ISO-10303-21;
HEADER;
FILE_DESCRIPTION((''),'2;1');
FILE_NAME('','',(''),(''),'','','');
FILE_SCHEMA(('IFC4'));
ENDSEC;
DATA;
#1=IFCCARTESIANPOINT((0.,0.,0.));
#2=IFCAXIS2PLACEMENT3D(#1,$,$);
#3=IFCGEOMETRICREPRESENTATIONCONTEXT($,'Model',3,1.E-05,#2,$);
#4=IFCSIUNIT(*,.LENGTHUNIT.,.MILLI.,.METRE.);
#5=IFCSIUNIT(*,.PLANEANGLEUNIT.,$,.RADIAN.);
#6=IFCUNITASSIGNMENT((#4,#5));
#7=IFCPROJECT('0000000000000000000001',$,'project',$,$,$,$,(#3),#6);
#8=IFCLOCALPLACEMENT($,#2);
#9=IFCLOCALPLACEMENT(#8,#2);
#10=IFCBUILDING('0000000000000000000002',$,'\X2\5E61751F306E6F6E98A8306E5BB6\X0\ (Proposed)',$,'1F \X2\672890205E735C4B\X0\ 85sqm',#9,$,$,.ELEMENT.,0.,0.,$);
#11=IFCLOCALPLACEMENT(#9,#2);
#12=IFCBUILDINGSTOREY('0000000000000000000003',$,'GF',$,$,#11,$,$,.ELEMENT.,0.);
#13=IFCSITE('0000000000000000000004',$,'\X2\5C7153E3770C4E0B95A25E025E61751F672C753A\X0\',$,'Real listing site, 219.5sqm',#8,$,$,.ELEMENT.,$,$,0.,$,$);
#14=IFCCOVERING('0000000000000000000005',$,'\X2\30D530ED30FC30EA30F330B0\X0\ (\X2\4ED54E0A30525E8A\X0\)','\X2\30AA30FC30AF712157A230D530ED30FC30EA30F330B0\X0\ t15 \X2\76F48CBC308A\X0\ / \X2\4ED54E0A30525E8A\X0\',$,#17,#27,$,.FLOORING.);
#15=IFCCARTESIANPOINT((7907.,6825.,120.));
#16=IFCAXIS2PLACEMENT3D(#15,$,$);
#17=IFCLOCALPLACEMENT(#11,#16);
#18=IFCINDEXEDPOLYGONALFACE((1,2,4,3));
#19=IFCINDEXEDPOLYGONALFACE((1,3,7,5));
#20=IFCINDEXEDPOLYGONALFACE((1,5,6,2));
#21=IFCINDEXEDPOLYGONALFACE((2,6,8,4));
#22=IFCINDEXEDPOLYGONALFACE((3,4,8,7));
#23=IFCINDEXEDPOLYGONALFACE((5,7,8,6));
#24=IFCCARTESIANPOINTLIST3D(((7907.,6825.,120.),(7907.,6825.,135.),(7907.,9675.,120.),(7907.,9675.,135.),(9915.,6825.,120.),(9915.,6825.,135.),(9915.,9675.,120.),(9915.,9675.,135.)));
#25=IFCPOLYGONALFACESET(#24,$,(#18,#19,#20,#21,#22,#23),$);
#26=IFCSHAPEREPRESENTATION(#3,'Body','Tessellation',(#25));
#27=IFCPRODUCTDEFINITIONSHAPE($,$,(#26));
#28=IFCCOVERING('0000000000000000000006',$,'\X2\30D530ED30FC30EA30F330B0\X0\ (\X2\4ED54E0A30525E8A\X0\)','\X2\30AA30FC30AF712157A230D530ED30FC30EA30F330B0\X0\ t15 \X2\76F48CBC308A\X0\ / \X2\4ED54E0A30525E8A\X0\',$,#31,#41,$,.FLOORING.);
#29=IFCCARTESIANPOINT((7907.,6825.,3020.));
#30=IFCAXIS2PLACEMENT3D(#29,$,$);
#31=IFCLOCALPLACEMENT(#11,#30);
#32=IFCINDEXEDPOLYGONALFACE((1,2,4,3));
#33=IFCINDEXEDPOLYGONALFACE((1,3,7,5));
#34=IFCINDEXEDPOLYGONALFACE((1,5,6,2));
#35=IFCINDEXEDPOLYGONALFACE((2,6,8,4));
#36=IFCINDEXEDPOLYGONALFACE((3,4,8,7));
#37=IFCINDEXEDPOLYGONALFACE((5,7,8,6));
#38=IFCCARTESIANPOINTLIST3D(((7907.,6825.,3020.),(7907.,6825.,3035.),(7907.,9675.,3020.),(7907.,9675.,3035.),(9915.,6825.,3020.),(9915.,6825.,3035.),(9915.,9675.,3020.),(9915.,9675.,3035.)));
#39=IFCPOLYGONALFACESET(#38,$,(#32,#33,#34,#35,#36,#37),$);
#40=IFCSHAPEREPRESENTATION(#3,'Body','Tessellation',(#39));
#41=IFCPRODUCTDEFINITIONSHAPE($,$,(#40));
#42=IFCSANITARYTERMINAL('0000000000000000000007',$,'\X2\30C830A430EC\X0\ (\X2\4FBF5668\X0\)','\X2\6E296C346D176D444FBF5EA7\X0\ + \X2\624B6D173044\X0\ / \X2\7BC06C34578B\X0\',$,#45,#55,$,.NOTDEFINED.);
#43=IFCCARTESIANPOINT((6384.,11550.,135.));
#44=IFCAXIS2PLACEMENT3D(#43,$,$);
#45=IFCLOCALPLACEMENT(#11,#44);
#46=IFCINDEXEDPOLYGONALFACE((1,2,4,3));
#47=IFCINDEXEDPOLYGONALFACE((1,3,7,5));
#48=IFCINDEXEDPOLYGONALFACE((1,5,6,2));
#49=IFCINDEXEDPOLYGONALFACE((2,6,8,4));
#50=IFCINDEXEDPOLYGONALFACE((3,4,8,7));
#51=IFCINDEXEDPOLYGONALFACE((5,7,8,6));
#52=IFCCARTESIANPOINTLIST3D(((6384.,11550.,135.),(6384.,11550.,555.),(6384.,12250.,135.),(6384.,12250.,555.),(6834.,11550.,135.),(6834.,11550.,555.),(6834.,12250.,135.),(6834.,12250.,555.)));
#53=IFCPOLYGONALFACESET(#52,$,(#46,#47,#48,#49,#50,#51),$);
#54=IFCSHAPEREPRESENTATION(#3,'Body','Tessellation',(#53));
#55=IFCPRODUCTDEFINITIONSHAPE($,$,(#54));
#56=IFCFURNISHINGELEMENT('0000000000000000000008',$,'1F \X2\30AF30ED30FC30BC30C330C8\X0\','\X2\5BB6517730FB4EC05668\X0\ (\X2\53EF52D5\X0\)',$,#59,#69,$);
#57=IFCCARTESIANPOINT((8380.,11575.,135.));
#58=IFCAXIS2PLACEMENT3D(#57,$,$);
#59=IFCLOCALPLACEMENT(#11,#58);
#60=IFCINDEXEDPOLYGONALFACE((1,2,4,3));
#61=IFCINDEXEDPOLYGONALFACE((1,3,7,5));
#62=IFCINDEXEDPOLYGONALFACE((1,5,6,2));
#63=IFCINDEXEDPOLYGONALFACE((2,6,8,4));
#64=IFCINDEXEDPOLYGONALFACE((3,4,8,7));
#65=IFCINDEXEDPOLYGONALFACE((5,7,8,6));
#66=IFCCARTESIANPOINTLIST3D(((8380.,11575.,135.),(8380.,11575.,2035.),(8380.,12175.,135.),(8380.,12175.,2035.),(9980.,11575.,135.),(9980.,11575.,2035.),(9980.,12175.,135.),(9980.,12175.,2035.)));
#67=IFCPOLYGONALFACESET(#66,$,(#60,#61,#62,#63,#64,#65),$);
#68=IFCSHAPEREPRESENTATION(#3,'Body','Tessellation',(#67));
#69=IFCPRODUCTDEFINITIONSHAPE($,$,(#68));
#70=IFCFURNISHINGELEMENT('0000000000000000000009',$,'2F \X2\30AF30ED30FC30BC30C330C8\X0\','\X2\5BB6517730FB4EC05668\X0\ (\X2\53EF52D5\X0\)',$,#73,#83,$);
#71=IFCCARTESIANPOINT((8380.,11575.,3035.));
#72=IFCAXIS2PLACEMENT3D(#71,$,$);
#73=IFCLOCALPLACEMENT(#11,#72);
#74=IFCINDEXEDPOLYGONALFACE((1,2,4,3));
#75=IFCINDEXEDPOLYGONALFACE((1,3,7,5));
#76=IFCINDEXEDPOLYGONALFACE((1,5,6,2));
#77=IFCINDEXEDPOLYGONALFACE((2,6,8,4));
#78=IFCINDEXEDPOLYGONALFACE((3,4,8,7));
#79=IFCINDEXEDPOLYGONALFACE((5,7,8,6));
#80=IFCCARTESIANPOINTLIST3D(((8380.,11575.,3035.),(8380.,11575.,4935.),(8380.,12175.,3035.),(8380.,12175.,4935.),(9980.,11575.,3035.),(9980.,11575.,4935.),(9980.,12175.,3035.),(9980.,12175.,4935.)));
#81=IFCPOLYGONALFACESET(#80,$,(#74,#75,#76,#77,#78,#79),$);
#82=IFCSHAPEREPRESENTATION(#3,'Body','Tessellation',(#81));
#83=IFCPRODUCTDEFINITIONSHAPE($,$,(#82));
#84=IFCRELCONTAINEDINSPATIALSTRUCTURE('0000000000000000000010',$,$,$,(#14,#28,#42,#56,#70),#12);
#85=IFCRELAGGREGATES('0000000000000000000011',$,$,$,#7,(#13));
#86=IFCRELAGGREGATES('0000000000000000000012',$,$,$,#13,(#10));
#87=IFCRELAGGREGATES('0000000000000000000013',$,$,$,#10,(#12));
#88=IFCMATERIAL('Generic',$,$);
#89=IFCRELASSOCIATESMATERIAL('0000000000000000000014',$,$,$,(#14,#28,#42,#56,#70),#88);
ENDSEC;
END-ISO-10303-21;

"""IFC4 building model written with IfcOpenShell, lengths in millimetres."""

from ifc_helpers import new_model, si_unit, frame, frame_2d, origin, place, context, project, spatial, rectangle, extrude, material, element, save


model = new_model("IFC4")

# Units and contexts
model_context = context("Model", 3, precision=1e-05, world=origin())
ifc_project = project(units=[si_unit("LENGTHUNIT", "METRE", prefix="MILLI"), si_unit("PLANEANGLEUNIT", "RADIAN")], contexts=[model_context])

# Site, building, storey
site_placement = place(None, origin())
site = spatial("IfcSite", under=ifc_project, at=site_placement, Name="山口県下関市幡生本町", ObjectType="Real listing site, 219.5sqm", CompositionType="ELEMENT", RefElevation=0.0)
building_placement = place(site_placement, origin())
building = spatial("IfcBuilding", under=site, at=building_placement, Name="幡生の潮風の家 (Proposed)", ObjectType="1F 木造平屋 85sqm", CompositionType="ELEMENT", ElevationOfRefHeight=0.0, ElevationOfTerrain=0.0)
storey_placement = place(building_placement, origin())
storey = spatial("IfcBuildingStorey", under=building, at=storey_placement, Name="GF", CompositionType="ELEMENT", Elevation=0.0)

# Shared definitions
ifc_material_1 = material(Name="Generic")

# Coverings
covering_1_placement = place(storey_placement, frame((7907.0, 6825.0, 120.0)))
element("IfcCovering", 1, at=covering_1_placement, inside=storey, material=ifc_material_1, Name="フローリング (仕上げ床)", Description="オーク無垢フローリング t15 直貼り / 仕上げ床", PredefinedType="FLOORING", context=model_context, shape_type="SweptSolid", body=[
    extrude(rectangle(XDim=2008.0, YDim=2850.0, at=frame_2d((1004.0, 1425.0))), frame((7907.0, 6825.0, 120.0)), (0.0, 0.0, 1.0), 15.0),
])
covering_2_placement = place(storey_placement, frame((7907.0, 6825.0, 3020.0)))
element("IfcCovering", 2, at=covering_2_placement, inside=storey, material=ifc_material_1, Name="フローリング (仕上げ床)", Description="オーク無垢フローリング t15 直貼り / 仕上げ床", PredefinedType="FLOORING", context=model_context, shape_type="SweptSolid", body=[
    extrude(rectangle(XDim=2008.0, YDim=2850.0, at=frame_2d((1004.0, 1425.0))), frame((7907.0, 6825.0, 3020.0)), (0.0, 0.0, 1.0), 15.0),
])

# Sanitary terminal
sanitary_terminal_placement = place(storey_placement, frame((6384.0, 11550.0, 135.0)))
element("IfcSanitaryTerminal", 3, at=sanitary_terminal_placement, inside=storey, material=ifc_material_1, Name="トイレ (便器)", Description="温水洗浄便座 + 手洗い / 節水型", PredefinedType="NOTDEFINED", context=model_context, shape_type="SweptSolid", body=[
    extrude(rectangle(XDim=450.0, YDim=700.0, at=frame_2d((225.0, 350.0))), frame((6384.0, 11550.0, 135.0)), (0.0, 0.0, 1.0), 420.0),
])

# Furnishing elements
furnishing_1_placement = place(storey_placement, frame((8380.0, 11575.0, 135.0)))
element("IfcFurnishingElement", 4, at=furnishing_1_placement, inside=storey, material=ifc_material_1, Name="1F クローゼット", Description="家具・什器 (可動)", context=model_context, shape_type="SweptSolid", body=[
    extrude(rectangle(XDim=1600.0, YDim=600.0, at=frame_2d((800.0, 300.0))), frame((8380.0, 11575.0, 135.0)), (0.0, 0.0, 1.0), 1900.0),
])
furnishing_2_placement = place(storey_placement, frame((8380.0, 11575.0, 3035.0)))
element("IfcFurnishingElement", 5, at=furnishing_2_placement, inside=storey, material=ifc_material_1, Name="2F クローゼット", Description="家具・什器 (可動)", context=model_context, shape_type="SweptSolid", body=[
    extrude(rectangle(XDim=1600.0, YDim=600.0, at=frame_2d((800.0, 300.0))), frame((8380.0, 11575.0, 3035.0)), (0.0, 0.0, 1.0), 1900.0),
])

save(model, "model.ifc")
